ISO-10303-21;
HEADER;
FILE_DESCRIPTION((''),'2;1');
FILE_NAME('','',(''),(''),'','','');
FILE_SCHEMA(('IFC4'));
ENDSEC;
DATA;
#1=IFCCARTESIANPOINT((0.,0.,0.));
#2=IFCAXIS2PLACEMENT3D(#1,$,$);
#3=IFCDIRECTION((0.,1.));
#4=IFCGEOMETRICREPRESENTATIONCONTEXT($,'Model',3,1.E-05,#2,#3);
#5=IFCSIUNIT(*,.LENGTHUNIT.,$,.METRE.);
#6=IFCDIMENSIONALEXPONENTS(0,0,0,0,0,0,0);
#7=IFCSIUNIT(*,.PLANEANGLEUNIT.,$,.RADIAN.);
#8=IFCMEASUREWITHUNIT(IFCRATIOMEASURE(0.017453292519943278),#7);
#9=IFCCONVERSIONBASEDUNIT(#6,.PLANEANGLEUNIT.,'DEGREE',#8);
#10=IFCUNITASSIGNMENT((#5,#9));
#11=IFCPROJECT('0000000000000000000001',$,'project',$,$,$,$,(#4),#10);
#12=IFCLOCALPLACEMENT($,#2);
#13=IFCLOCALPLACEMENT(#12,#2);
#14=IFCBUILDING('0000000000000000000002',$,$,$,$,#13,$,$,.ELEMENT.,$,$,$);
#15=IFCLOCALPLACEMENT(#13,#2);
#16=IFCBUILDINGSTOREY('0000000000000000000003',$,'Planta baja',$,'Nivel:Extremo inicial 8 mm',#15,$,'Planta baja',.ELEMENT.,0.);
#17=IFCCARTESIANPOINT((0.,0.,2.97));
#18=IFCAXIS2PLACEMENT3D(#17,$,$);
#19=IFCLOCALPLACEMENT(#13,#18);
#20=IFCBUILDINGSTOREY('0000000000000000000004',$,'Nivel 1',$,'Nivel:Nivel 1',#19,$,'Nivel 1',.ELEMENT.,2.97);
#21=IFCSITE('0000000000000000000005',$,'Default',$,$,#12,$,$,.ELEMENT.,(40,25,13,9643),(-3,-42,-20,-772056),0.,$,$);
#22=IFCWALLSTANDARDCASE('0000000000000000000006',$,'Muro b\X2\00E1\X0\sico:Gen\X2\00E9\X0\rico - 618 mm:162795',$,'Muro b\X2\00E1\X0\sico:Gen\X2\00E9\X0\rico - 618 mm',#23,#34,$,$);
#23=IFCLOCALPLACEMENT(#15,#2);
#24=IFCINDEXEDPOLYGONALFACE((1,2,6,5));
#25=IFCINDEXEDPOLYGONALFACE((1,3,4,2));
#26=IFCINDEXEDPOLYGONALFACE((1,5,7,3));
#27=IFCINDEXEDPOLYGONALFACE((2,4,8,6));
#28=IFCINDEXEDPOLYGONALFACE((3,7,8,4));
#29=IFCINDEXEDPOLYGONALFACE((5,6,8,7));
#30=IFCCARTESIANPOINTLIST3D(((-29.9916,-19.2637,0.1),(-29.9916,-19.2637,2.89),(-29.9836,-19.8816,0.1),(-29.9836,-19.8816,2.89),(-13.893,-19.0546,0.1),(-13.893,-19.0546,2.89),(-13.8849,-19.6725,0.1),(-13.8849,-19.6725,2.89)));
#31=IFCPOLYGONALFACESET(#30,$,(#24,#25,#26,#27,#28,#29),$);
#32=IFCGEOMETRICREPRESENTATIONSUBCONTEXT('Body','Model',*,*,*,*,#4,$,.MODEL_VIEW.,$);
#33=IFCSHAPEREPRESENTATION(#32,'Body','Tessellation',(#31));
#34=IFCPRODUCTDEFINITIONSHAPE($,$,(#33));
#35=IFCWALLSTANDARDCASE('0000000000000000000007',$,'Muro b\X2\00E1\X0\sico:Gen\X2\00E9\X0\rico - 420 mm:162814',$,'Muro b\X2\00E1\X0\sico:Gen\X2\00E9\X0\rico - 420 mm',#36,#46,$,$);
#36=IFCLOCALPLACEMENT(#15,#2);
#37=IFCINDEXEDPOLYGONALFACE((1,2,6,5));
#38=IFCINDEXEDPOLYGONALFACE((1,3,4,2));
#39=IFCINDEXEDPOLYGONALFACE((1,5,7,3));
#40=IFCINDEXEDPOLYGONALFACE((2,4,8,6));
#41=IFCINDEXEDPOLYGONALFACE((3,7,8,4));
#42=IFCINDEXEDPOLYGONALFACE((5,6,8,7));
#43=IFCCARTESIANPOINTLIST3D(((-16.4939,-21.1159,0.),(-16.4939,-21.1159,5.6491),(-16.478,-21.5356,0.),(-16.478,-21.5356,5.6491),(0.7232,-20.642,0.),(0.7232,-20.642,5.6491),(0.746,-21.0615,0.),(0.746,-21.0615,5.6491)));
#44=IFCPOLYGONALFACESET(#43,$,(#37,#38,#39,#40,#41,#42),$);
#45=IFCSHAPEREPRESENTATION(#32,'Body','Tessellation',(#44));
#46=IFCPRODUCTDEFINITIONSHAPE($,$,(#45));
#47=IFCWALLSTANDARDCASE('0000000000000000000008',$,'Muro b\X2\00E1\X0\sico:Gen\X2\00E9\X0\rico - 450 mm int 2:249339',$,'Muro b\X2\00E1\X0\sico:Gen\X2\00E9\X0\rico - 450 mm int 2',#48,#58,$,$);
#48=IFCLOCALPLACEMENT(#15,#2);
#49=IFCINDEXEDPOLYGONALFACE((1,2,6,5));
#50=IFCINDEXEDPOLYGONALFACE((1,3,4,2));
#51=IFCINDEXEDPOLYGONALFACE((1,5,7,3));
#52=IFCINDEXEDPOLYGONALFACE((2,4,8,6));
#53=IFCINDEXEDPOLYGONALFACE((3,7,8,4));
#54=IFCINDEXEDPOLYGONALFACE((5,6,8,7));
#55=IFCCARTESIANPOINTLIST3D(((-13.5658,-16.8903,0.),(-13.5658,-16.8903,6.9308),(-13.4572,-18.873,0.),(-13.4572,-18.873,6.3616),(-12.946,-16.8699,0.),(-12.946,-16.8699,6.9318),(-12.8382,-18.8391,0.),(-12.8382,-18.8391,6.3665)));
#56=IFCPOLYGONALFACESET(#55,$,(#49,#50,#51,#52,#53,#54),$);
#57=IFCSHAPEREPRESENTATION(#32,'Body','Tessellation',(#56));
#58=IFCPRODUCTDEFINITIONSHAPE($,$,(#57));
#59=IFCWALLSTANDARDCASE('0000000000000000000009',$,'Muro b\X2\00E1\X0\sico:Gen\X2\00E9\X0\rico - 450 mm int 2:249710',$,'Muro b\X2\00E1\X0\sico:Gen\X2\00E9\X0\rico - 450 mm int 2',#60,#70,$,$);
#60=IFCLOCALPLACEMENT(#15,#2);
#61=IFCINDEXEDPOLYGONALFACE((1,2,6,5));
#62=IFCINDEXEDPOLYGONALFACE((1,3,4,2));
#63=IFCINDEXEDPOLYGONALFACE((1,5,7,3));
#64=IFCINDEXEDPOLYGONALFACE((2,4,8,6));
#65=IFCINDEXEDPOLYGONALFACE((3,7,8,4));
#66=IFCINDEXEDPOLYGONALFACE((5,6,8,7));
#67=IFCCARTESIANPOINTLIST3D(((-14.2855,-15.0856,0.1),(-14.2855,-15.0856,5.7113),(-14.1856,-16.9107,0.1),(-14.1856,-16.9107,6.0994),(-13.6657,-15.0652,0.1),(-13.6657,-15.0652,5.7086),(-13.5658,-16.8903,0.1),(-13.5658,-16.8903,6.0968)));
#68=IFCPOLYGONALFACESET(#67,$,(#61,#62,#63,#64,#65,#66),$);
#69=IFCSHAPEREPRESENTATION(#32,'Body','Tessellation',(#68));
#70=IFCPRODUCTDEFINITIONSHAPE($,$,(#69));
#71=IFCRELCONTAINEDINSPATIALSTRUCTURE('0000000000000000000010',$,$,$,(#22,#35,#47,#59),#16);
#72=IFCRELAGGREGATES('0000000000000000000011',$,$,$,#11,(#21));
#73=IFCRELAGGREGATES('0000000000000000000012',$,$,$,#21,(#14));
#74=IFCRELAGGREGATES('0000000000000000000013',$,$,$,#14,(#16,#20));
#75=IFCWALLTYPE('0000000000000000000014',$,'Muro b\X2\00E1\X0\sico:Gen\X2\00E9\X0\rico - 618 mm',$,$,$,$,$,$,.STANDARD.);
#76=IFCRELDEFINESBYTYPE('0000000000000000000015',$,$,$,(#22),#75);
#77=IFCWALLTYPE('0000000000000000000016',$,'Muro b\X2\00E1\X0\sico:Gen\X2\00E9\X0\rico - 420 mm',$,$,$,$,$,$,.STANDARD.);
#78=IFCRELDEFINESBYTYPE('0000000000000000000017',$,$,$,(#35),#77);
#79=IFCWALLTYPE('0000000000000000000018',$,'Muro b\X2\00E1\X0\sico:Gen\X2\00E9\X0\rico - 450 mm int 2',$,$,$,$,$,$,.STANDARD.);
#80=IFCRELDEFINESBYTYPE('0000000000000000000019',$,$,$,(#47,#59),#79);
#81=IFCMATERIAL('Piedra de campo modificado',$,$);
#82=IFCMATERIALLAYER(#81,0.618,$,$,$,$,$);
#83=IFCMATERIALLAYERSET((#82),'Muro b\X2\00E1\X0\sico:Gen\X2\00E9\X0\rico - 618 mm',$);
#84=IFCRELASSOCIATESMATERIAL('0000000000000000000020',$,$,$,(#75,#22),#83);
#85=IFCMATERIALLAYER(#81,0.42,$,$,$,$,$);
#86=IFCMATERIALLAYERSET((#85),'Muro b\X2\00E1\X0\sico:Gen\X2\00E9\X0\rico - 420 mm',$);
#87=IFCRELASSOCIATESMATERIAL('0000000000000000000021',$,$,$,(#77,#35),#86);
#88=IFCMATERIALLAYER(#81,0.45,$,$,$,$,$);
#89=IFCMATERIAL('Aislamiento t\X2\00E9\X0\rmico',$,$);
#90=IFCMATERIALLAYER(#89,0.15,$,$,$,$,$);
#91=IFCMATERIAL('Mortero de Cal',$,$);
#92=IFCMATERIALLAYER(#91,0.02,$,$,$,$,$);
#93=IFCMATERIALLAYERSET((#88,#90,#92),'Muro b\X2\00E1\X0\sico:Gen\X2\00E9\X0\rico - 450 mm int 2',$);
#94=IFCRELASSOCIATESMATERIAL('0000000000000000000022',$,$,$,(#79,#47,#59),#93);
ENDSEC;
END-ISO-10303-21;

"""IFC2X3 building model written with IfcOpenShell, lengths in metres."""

from ifc_helpers import new_model, entity, si_unit, converted_unit, direction, frame, frame_2d, origin, place, context, subcontext, project, spatial, polyline, rectangle, outline, extrude, clip, bounded_halfspace, material, layer, layer_set, layer_usage, type_object, element, save


model = new_model("IFC2X3")

# Units and contexts
model_context = context("Model", 3, precision=1e-05, world=origin(), true_north=direction((0.0, 1.0)))
body_context = subcontext(model_context, "Body", "Model", "MODEL_VIEW")
ifc_project = project(units=[si_unit("LENGTHUNIT", "METRE"), converted_unit("PLANEANGLEUNIT", "DEGREE", entity("IfcRatioMeasure", 0.017453292519943278), si_unit("PLANEANGLEUNIT", "RADIAN"), dimensions=[0, 0, 0, 0, 0, 0, 0])], contexts=[model_context])

# Site, building, storey
site_placement = place(None, origin())
site = spatial("IfcSite", under=ifc_project, at=site_placement, Name="Default", CompositionType="ELEMENT", RefLatitude=(40, 25, 13, 9643), RefLongitude=(-3, -42, -20, -772056), RefElevation=0.0)
building_placement = place(site_placement, origin())
building = spatial("IfcBuilding", under=site, at=building_placement, CompositionType="ELEMENT")
storey_1_placement = place(building_placement, origin())
storey_1 = spatial("IfcBuildingStorey", under=building, at=storey_1_placement, Name="Planta baja", ObjectType="Nivel:Extremo inicial 8 mm", LongName="Planta baja", CompositionType="ELEMENT", Elevation=0.0)

# Wall
ifc_material_1 = material(Name="Piedra de campo modificado")
ifc_layer_1 = layer(ifc_material_1, 0.618)
ifc_layer_set_1 = layer_set([ifc_layer_1], Name="Muro básico:Genérico - 618 mm")
ifc_layer_usage_1 = layer_usage(ifc_layer_set_1, "AXIS2", "NEGATIVE", 0.309)
wall_type_1 = type_object("IfcWallType", Name="Muro básico:Genérico - 618 mm", PredefinedType="STANDARD", material=ifc_layer_set_1)
wall_1_placement = place(storey_1_placement, frame((-13.8889, -19.3635, 0.1), z_axis=(0.0, 0.0, 1.0), x_axis=(-0.999916, -0.01299, 0.0)))
element("IfcWallStandardCase", 1, at=wall_1_placement, inside=storey_1, type_object=wall_type_1, material=ifc_layer_usage_1, Name="Muro básico:Genérico - 618 mm:162795", ObjectType="Muro básico:Genérico - 618 mm", context=body_context, shape_type="Clipping", body=[
    clip(extrude(rectangle(XDim=16.1, YDim=0.618, at=frame_2d((8.05, 0.0), x_axis=(-1.0, 0.0))), origin(), (0.0, 0.0, 1.0), 2.79), bounded_halfspace(frame((0.0, -0.309, 2.79), z_axis=(0.0, 0.0, -1.0), x_axis=(0.028555, -0.999592, 0.0)), True, frame((0.0, -0.309, 2.79)), polyline([(0.0, 0.0), (16.1, 0.0), (16.1, 0.618), (0.0, 0.618), (0.0, 0.0)]))),
])

# Shared definitions
ifc_material_2 = material(Name="Mortero de Cal")
ifc_material_3 = material(Name="Aislamiento térmico")

# Shared definitions
storey_2_placement = place(building_placement, frame((0.0, 0.0, 2.97)))
storey_2 = spatial("IfcBuildingStorey", under=building, at=storey_2_placement, Name="Nivel 1", ObjectType="Nivel:Nivel 1", LongName="Nivel 1", CompositionType="ELEMENT", Elevation=2.97)

# Walls
ifc_layer_2 = layer(ifc_material_1, 0.42)
ifc_layer_set_2 = layer_set([ifc_layer_2], Name="Muro básico:Genérico - 420 mm")
ifc_layer_usage_2 = layer_usage(ifc_layer_set_2, "AXIS2", "NEGATIVE", 0.21)
wall_type_2 = type_object("IfcWallType", Name="Muro básico:Genérico - 420 mm", PredefinedType="STANDARD", material=ifc_layer_set_2)
wall_2_placement = place(storey_1_placement, frame((-16.4881, -21.3258, 0.0), z_axis=(0.0, 0.0, 1.0), x_axis=(0.999621, 0.027514, 0.0)))
element("IfcWallStandardCase", 2, at=wall_2_placement, inside=storey_1, type_object=wall_type_2, material=ifc_layer_usage_2, Name="Muro básico:Genérico - 420 mm:162814", ObjectType="Muro básico:Genérico - 420 mm", context=body_context, shape_type="SweptSolid", body=[
    extrude(outline(polyline([(17.2348, -0.21), (17.2236, 0.21), (0.0, 0.21), (0.0043, -0.21), (17.2348, -0.21)])), origin(), (0.0, 0.0, 1.0), 5.6491),
])
ifc_layer_3 = layer(ifc_material_1, 0.45)
ifc_layer_4 = layer(ifc_material_3, 0.15)
ifc_layer_5 = layer(ifc_material_2, 0.02)
ifc_layer_set_3 = layer_set([ifc_layer_3, ifc_layer_4, ifc_layer_5], Name="Muro básico:Genérico - 450 mm int 2")
ifc_layer_usage_3 = layer_usage(ifc_layer_set_3, "AXIS2", "NEGATIVE", 0.31)
wall_type_3 = type_object("IfcWallType", Name="Muro básico:Genérico - 450 mm int 2", PredefinedType="STANDARD", material=ifc_layer_set_3)
wall_3_placement = place(storey_1_placement, frame((-13.2562, -16.8733, 0.0), z_axis=(0.0, 0.0, 1.0), x_axis=(0.054661, -0.998505, 0.0)))
element("IfcWallStandardCase", 3, at=wall_3_placement, inside=storey_1, type_object=wall_type_3, material=ifc_layer_usage_3, Name="Muro básico:Genérico - 450 mm int 2:249339", ObjectType="Muro básico:Genérico - 450 mm int 2", context=body_context, shape_type="Clipping", body=[
    clip(extrude(outline(polyline([(1.9857, -0.31), (1.9857, 0.31), (0.0135, 0.31), (0.0, -0.31), (1.9857, -0.31)])), origin(), (0.0, 0.0, 1.0), 6.9318), bounded_halfspace(frame((0.0, -0.31, 6.9308), z_axis=(0.275536, -0.007488, 0.961262), x_axis=(0.027168, 0.999631, 0.0)), False, frame((0.0, -0.31, 6.9308)), polyline([(0.0, 0.0), (1.9857, 0.0), (1.9857, 0.62), (0.0135, 0.62), (0.0, 0.0)]))),
])
wall_4_placement = place(storey_1_placement, frame((-13.8753, -16.9072, 0.1), z_axis=(0.0, 0.0, 1.0), x_axis=(-0.054661, 0.998505, 0.0)))
element("IfcWallStandardCase", 4, at=wall_4_placement, inside=storey_1, type_object=wall_type_3, material=ifc_layer_usage_3, Name="Muro básico:Genérico - 450 mm int 2:249710", ObjectType="Muro básico:Genérico - 450 mm int 2", context=body_context, shape_type="Clipping", body=[
    clip(extrude(outline(polyline([(1.8278, -0.31), (1.8413, 0.31), (1.2211, 0.31), (0.0135, 0.31), (0.0, -0.31), (1.8278, -0.31)])), origin(), (0.0, 0.0, 1.0), 5.9994), bounded_halfspace(frame((0.0, -0.31, 5.9968), z_axis=(0.207732, -0.008646, 0.978148), x_axis=(0.041585, 0.999135, 0.0)), False, frame((0.0, -0.31, 5.9968)), polyline([(0.0, 0.0), (1.8278, 0.0), (1.8413, 0.62), (1.2211, 0.62), (0.0135, 0.62), (0.0, 0.0)]))),
])

save(model, "model.ifc")
